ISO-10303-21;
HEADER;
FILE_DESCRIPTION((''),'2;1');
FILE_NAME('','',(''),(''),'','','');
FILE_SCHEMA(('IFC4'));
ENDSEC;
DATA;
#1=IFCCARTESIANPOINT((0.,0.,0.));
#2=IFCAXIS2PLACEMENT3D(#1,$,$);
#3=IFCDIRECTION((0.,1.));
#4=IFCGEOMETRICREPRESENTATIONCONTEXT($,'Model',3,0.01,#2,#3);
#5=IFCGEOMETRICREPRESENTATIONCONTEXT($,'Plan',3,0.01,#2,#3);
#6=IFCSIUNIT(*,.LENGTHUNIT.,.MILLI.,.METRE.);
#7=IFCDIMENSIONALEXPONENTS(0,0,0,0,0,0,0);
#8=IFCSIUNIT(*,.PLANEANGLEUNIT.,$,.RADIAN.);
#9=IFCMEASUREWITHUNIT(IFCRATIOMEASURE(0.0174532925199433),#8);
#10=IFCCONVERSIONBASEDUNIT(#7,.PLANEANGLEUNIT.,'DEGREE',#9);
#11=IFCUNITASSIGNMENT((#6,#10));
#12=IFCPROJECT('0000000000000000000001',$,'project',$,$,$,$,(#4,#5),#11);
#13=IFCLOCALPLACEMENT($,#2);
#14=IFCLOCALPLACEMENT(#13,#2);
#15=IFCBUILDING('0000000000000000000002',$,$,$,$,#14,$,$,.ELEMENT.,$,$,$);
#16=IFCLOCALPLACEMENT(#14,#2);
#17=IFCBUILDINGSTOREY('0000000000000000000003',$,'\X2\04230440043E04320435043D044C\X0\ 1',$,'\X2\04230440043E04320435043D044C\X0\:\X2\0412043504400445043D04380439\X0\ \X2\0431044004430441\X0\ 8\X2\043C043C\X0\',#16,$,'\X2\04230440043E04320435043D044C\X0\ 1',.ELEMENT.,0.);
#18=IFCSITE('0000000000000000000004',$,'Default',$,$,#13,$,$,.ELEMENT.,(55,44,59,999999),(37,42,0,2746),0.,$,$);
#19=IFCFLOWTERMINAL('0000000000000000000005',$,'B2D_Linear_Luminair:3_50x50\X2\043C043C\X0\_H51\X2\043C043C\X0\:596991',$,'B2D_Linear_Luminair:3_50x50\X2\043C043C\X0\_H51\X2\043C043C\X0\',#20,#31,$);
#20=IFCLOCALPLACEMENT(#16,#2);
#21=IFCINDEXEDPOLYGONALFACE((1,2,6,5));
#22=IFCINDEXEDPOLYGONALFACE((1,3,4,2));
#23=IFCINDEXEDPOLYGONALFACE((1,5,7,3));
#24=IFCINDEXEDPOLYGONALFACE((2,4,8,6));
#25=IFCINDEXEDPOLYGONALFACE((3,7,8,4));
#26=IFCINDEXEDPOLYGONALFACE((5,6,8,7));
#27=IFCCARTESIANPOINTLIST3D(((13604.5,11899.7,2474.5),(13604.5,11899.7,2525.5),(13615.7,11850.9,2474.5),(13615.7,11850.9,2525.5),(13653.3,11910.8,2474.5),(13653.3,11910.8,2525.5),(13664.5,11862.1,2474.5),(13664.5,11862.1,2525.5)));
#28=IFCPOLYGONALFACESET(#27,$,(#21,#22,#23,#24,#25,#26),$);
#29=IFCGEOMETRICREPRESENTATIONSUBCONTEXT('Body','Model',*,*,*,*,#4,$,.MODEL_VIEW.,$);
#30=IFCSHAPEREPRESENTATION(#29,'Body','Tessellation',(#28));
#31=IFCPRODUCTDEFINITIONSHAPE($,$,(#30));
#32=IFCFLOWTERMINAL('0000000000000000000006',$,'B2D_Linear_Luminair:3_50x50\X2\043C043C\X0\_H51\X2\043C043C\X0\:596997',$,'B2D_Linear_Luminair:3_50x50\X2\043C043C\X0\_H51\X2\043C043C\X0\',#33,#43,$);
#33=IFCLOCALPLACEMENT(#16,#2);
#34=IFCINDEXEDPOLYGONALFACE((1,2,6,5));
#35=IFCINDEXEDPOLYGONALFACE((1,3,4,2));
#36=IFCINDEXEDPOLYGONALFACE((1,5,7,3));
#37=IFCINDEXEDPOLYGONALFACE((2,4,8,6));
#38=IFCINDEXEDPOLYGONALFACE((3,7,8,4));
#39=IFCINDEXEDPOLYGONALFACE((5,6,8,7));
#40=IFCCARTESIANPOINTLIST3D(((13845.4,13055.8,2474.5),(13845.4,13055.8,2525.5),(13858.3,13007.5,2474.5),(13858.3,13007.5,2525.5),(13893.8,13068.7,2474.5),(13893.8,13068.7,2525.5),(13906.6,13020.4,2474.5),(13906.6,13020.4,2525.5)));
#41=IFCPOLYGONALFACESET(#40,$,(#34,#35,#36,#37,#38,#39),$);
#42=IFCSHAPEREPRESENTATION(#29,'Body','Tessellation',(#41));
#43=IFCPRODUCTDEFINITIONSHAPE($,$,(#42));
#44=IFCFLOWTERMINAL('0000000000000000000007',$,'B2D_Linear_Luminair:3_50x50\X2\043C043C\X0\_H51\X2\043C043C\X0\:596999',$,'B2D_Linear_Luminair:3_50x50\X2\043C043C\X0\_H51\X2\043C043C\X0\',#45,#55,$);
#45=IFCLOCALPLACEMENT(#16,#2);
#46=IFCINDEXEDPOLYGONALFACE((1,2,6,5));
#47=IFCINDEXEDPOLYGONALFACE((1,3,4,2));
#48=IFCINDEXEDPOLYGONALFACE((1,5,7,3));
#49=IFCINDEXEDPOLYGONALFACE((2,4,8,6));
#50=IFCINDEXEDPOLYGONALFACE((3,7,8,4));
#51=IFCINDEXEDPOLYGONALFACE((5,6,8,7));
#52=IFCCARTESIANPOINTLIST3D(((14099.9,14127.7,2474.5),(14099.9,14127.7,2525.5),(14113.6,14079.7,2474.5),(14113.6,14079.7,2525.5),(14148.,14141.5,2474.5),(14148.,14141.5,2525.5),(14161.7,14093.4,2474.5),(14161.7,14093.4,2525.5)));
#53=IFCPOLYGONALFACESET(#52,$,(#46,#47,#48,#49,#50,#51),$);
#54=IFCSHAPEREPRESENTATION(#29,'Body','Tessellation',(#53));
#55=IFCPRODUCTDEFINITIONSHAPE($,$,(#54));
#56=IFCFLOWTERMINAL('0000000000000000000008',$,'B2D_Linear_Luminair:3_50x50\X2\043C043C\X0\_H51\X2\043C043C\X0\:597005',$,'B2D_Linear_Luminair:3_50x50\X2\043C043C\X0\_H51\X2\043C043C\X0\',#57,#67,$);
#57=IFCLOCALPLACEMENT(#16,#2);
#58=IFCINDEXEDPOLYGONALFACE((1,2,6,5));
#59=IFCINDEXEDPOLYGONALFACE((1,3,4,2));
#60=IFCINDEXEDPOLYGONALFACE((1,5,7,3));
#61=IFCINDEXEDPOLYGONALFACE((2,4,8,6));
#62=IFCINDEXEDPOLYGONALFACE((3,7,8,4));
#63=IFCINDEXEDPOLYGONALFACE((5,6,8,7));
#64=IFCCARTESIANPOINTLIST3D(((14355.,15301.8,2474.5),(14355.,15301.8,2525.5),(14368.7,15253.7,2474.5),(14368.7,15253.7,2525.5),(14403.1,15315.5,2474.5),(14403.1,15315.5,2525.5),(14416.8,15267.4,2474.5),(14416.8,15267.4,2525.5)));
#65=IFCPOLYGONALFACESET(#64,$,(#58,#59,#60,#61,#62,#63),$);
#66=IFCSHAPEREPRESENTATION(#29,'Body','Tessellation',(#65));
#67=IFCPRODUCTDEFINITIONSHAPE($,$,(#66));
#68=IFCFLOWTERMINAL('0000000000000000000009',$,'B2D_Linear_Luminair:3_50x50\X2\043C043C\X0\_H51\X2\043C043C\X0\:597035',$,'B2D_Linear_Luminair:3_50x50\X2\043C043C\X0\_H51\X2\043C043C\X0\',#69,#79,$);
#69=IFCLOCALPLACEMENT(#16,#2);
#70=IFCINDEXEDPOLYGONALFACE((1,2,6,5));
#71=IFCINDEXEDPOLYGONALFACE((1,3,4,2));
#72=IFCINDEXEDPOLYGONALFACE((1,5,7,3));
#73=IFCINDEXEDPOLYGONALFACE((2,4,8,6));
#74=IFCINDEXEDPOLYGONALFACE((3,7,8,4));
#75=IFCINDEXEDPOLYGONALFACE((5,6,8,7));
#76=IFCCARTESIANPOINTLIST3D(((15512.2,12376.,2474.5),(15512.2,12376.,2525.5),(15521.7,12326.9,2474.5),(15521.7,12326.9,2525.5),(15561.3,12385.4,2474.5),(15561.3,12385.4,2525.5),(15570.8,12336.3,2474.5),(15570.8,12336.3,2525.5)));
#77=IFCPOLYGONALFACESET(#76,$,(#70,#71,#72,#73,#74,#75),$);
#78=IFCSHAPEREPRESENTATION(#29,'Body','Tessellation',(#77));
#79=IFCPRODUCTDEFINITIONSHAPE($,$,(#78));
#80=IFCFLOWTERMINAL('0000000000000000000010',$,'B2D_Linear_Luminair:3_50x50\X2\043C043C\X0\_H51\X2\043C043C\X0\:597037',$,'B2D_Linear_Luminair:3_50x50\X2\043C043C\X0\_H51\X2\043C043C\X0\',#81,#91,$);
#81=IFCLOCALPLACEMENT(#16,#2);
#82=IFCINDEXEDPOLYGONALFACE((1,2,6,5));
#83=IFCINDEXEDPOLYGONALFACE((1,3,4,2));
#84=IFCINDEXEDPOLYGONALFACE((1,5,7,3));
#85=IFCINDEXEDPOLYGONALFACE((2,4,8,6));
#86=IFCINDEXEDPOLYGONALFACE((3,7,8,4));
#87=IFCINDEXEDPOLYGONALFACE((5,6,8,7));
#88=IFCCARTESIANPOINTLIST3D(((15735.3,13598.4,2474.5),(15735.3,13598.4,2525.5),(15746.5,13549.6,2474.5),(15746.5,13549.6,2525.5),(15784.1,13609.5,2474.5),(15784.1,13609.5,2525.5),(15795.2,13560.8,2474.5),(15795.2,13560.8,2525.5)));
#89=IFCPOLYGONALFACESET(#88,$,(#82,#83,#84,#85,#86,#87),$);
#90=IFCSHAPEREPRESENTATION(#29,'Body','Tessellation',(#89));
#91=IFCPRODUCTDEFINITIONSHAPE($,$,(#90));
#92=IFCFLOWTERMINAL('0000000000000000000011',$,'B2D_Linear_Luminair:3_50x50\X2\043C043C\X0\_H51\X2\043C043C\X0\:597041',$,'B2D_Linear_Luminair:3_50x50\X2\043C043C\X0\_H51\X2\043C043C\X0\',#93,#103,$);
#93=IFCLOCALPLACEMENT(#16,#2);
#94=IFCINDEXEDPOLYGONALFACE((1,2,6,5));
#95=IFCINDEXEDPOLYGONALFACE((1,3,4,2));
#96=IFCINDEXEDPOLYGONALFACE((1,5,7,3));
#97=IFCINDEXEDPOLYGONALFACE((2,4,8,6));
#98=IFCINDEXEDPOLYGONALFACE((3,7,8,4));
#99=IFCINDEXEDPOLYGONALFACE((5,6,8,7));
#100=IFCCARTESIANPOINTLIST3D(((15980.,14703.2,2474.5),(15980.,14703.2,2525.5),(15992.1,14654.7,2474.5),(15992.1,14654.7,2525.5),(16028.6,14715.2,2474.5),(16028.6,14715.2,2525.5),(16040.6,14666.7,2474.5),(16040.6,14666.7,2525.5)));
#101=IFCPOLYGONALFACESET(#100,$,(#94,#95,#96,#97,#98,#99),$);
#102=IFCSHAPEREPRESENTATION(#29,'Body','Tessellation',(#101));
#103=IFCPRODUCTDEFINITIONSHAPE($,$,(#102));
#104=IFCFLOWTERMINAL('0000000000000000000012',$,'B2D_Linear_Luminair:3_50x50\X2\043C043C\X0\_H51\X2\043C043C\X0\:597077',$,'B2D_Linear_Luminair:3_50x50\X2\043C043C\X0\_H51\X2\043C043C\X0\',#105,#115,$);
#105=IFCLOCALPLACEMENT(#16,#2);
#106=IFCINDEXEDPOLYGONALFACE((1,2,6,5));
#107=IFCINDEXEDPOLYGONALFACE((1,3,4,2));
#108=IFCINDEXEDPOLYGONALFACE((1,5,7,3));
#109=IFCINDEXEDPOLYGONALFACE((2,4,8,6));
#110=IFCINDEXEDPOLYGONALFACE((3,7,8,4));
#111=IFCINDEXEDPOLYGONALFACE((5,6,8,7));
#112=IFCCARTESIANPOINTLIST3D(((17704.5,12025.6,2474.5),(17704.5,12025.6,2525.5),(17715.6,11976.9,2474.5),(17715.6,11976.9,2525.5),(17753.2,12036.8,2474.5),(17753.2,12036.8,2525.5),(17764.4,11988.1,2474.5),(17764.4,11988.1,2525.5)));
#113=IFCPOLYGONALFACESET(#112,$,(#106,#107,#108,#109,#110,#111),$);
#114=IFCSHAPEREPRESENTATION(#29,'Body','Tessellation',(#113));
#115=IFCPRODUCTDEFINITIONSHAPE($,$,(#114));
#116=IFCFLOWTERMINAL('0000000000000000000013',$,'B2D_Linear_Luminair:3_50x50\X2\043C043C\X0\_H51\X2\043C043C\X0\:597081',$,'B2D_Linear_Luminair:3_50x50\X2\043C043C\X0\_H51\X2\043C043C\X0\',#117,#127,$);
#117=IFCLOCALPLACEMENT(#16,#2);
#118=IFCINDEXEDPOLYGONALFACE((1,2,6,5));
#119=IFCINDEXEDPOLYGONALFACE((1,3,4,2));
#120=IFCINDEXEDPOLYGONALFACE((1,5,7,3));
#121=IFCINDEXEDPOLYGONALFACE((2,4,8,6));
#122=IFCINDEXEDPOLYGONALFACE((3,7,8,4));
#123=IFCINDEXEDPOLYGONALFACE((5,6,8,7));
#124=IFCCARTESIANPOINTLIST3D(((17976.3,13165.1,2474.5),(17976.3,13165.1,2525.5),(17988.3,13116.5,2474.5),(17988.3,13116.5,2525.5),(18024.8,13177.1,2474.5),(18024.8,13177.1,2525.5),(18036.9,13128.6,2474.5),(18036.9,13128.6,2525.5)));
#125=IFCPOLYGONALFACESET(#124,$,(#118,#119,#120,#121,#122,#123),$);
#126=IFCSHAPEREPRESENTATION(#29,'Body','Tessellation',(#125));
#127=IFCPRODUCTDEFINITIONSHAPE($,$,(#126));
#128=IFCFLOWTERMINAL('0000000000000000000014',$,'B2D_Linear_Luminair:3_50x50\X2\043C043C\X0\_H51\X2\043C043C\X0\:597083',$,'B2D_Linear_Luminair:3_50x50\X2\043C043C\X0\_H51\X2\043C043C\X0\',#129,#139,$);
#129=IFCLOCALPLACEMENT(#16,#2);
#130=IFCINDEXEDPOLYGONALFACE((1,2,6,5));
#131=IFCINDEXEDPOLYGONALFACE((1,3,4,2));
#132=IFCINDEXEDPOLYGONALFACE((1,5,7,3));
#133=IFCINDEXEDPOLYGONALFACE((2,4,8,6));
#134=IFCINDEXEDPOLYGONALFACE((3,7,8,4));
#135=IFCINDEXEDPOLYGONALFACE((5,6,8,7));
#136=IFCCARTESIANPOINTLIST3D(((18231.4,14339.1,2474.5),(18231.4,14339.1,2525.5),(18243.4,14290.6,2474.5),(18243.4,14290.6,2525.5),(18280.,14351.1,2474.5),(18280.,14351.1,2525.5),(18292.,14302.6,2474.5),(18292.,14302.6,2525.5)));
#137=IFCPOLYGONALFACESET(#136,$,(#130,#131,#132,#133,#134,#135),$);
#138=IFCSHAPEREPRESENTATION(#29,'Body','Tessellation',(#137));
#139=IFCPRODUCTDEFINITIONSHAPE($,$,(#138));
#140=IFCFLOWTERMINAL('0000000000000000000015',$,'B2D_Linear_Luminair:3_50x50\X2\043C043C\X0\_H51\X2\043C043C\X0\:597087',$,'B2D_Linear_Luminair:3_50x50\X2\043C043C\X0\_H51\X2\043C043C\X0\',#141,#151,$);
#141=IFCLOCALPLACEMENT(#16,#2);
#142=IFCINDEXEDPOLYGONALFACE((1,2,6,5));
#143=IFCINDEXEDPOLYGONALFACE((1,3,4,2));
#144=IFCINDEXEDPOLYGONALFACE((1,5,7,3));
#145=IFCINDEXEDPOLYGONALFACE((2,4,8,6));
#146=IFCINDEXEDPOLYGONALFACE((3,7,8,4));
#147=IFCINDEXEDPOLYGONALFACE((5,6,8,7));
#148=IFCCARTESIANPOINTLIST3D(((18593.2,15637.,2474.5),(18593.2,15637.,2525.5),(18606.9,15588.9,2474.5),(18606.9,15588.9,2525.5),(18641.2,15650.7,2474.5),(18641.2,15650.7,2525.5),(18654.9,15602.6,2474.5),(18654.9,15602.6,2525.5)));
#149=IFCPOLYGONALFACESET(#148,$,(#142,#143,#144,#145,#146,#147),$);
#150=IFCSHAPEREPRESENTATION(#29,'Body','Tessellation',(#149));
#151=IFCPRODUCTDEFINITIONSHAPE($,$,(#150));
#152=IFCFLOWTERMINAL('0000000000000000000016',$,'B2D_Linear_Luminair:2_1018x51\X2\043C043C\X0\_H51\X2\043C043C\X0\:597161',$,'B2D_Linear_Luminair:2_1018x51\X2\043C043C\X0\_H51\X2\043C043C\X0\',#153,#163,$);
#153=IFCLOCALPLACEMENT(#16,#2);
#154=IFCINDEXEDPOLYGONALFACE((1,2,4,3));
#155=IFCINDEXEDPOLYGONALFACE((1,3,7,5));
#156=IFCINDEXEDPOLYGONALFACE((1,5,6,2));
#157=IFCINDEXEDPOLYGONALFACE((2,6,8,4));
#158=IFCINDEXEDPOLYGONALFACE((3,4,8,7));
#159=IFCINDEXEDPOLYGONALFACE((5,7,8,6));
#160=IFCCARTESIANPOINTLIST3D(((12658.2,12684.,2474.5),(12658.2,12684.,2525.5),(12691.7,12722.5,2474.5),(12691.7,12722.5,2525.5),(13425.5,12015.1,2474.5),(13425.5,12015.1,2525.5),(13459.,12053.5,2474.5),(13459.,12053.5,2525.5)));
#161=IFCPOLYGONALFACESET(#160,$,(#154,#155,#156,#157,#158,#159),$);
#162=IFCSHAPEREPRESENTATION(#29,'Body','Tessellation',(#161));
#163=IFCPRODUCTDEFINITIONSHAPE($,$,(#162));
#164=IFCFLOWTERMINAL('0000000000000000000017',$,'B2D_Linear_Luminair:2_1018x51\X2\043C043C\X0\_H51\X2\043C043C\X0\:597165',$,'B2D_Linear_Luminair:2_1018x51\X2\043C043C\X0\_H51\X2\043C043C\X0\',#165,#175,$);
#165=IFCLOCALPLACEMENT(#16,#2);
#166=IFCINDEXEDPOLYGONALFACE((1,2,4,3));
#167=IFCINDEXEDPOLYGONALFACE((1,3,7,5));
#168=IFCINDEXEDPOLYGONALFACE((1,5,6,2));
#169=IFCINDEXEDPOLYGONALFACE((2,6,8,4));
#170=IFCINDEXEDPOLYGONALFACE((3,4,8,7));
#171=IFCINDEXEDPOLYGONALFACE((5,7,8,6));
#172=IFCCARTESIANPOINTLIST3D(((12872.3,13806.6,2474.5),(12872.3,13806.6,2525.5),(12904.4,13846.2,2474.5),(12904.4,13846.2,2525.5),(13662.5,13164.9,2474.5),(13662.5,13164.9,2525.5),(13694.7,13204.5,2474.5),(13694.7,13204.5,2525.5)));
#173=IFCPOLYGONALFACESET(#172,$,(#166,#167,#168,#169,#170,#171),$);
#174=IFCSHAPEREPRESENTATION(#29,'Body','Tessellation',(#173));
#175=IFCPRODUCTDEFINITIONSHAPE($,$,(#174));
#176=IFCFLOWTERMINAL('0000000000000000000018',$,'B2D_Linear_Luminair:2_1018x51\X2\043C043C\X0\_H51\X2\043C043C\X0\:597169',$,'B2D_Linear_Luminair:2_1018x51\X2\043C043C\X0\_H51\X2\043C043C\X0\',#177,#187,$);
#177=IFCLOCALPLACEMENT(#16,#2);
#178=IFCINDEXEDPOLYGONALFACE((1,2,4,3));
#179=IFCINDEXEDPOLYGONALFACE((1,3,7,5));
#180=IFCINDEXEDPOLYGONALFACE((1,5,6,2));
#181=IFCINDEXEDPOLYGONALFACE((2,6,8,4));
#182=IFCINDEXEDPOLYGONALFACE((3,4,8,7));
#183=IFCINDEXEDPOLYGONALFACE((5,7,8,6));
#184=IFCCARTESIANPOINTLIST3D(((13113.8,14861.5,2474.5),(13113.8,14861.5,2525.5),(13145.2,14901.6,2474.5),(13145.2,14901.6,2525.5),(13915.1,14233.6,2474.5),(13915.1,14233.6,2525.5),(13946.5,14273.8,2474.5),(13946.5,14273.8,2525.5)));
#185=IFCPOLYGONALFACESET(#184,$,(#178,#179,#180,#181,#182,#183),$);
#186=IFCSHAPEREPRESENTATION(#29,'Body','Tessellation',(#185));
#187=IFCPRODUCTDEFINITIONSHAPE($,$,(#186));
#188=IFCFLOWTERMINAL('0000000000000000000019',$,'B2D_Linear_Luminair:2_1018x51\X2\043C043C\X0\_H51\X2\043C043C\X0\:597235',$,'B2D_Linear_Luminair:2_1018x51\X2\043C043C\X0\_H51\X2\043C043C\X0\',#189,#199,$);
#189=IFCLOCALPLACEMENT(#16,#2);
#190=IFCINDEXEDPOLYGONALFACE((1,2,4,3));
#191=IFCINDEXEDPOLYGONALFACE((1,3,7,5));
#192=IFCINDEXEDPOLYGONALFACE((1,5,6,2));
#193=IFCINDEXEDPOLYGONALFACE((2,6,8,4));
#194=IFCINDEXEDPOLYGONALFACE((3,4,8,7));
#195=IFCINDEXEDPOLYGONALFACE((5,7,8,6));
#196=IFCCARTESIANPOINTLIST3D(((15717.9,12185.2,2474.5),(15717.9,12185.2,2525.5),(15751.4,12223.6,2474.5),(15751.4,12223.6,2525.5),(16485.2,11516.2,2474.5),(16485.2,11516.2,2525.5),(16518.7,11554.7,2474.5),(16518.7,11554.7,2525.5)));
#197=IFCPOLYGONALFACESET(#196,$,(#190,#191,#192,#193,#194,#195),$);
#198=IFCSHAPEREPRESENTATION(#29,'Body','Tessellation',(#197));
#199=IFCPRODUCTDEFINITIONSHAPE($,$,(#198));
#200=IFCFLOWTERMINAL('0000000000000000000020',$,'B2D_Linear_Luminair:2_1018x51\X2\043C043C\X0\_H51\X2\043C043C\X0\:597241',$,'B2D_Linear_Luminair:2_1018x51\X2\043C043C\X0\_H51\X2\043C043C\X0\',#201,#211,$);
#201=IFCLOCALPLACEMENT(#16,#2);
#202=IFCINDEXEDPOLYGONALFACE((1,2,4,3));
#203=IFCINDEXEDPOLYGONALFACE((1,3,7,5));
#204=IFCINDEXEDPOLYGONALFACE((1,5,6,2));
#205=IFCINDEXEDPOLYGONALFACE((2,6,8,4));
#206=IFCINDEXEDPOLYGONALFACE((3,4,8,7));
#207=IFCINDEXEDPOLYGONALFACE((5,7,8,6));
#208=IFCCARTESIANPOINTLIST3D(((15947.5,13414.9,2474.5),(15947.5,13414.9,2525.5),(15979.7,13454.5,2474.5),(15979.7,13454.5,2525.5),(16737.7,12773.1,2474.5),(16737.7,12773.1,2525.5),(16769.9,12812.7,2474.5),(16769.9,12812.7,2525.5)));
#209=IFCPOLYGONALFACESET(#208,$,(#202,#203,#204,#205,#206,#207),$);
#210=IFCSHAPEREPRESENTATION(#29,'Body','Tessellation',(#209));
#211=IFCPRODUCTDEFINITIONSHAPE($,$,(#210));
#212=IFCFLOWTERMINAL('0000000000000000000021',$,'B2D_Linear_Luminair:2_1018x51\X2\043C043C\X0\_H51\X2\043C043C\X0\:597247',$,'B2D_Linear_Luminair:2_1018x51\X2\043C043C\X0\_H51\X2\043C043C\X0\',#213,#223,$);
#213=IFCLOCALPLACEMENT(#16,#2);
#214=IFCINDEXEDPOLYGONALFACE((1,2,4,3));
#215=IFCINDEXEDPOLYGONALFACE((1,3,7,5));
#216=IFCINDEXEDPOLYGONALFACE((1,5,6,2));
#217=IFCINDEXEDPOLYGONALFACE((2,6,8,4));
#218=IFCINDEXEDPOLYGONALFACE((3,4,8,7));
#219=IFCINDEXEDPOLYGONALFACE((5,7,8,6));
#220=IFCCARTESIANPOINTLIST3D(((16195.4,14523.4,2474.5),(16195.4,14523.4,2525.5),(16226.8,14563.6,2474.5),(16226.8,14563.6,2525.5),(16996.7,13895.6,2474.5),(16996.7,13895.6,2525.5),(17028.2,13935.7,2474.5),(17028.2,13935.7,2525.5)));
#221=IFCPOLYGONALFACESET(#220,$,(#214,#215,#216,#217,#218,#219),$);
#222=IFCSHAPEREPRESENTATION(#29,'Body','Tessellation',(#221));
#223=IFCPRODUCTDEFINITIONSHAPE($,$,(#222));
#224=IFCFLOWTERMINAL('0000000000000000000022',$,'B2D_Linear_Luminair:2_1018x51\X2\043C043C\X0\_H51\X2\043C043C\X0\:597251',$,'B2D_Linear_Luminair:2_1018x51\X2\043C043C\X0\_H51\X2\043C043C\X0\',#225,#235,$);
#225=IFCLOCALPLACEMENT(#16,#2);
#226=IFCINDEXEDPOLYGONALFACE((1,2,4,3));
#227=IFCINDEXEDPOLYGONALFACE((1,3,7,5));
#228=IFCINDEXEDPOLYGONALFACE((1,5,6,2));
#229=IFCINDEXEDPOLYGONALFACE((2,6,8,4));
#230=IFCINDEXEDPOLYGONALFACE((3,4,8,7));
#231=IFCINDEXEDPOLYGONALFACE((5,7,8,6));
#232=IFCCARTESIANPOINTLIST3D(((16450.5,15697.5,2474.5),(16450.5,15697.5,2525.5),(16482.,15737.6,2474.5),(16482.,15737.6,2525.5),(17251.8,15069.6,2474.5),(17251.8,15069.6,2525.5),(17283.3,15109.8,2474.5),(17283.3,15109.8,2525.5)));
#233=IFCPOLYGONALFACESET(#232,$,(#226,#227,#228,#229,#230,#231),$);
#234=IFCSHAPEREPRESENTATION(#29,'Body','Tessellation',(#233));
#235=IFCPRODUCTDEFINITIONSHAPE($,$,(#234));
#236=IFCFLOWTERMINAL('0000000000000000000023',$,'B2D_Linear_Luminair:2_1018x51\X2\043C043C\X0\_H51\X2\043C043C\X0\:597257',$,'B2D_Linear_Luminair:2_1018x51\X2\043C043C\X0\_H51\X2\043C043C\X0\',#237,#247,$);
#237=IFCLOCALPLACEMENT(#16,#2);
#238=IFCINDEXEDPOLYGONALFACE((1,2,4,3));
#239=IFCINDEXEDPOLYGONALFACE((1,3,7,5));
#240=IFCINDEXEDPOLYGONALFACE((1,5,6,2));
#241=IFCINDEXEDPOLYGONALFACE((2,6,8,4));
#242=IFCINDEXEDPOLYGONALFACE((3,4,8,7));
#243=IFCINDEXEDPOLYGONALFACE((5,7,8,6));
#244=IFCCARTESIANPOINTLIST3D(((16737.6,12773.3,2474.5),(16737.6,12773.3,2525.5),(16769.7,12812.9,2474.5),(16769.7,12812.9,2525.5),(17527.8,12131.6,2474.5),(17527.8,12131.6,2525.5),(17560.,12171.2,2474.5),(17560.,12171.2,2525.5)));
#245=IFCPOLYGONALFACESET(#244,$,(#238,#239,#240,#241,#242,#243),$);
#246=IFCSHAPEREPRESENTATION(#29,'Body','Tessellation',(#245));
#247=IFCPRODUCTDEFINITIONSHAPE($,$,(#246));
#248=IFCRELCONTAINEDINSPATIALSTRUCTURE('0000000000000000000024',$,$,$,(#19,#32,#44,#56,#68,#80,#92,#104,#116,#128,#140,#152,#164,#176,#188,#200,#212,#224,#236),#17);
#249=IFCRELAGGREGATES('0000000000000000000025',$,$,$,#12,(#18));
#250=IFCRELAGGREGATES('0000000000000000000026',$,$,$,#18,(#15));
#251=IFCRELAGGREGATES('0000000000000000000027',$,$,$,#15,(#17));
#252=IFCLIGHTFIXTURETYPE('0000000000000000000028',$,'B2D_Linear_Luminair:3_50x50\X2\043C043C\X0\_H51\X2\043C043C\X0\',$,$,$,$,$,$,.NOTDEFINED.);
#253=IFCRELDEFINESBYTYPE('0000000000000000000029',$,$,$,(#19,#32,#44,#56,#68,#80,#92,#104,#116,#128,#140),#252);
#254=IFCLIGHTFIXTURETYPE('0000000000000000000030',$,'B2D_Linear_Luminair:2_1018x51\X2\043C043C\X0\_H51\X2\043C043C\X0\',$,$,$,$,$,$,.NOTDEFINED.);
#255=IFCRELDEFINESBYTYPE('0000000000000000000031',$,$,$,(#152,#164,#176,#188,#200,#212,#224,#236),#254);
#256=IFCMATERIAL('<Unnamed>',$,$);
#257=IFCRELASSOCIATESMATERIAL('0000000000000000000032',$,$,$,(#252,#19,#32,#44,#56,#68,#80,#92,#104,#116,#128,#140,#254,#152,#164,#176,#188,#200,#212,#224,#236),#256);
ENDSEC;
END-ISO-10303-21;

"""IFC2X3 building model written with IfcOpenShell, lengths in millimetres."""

from ifc_helpers import new_model, entity, si_unit, converted_unit, direction, frame, origin, origin_2d_with_axis, place, context, subcontext, project, spatial, rectangle, extrude, source, transform, mapped, material, type_object, type_shapes, element, save


model = new_model("IFC2X3")

# Units and contexts
model_context = context("Model", 3, precision=0.01, world=origin(), true_north=direction((0.0, 1.0)))
plan_context = context("Plan", 3, precision=0.01, world=origin(), true_north=direction((0.0, 1.0)))
body_context = subcontext(model_context, "Body", "Model", "MODEL_VIEW")
ifc_project = project(units=[si_unit("LENGTHUNIT", "METRE", prefix="MILLI"), converted_unit("PLANEANGLEUNIT", "DEGREE", entity("IfcRatioMeasure", 0.0174532925199433), si_unit("PLANEANGLEUNIT", "RADIAN"), dimensions=[0, 0, 0, 0, 0, 0, 0])], contexts=[model_context, plan_context])

# Site, building, storey
site_placement = place(None, origin())
site = spatial("IfcSite", under=ifc_project, at=site_placement, Name="Default", CompositionType="ELEMENT", RefLatitude=(55, 44, 59, 999999), RefLongitude=(37, 42, 0, 2746), RefElevation=0.0)
building_placement = place(site_placement, origin())
building = spatial("IfcBuilding", under=site, at=building_placement, CompositionType="ELEMENT")
storey_placement = place(building_placement, origin())
storey = spatial("IfcBuildingStorey", under=building, at=storey_placement, Name="Уровень 1", ObjectType="Уровень:Верхний брус 8мм", LongName="Уровень 1", CompositionType="ELEMENT", Elevation=0.0)

# Flow terminals
ifc_material = material(Name="<Unnamed>")
light_fixture_type_1 = type_object("IfcLightFixtureType", Name="B2D_Linear_Luminair:3_50x50мм_H51мм", PredefinedType="NOTDEFINED", material=ifc_material)
shared_shape_1 = source(origin(), body_context, "Body", "SweptSolid", [
    extrude(rectangle(XDim=50.0, YDim=50.0, at=origin_2d_with_axis()), frame((0.0, 0.0, 0.0), z_axis=(0.0, 0.0, 1.0), x_axis=(-1.0, 0.0, 0.0)), (0.0, 0.0, 1.0), 51.0),
])
type_shapes(light_fixture_type_1, [shared_shape_1])
for number, where, z_axis, x_axis, name in (
    (1, (13634.5, 11880.9, 2525.5), (0.0, 0.0, -1.0), (0.974683, 0.22359, 0.0), "B2D_Linear_Luminair:3_50x50мм_H51мм:596991"),
    (2, (13876.0, 13038.1, 2525.5), (0.0, 0.0, -1.0), (0.966286, 0.25747, 0.0), "B2D_Linear_Luminair:3_50x50мм_H51мм:596997"),
    (3, (14130.8, 14110.6, 2525.5), (0.0, 0.0, -1.0), (0.961646, 0.274295, 0.0), "B2D_Linear_Luminair:3_50x50мм_H51мм:596999"),
    (4, (14385.9, 15284.6, 2525.5), (0.0, 0.0, -1.0), (0.961646, 0.274295, 0.0), "B2D_Linear_Luminair:3_50x50мм_H51мм:597005"),
    (5, (15541.5, 12356.1, 2525.5), (0.0, 0.0, -1.0), (0.981893, 0.189438, 0.0), "B2D_Linear_Luminair:3_50x50мм_H51мм:597035"),
    (6, (15765.3, 13579.6, 2525.5), (0.0, 0.0, -1.0), (0.974683, 0.22359, 0.0), "B2D_Linear_Luminair:3_50x50мм_H51мм:597037"),
    (7, (16010.3, 14685.0, 2525.5), (0.0, 0.0, -1.0), (0.970633, 0.240567, 0.0), "B2D_Linear_Luminair:3_50x50мм_H51мм:597041"),
    (8, (17734.4, 12006.9, 2525.5), (0.0, 0.0, -1.0), (0.974683, 0.22359, 0.0), "B2D_Linear_Luminair:3_50x50мм_H51мм:597077"),
    (9, (18006.6, 13146.8, 2525.5), (0.0, 0.0, -1.0), (0.970633, 0.240567, 0.0), "B2D_Linear_Luminair:3_50x50мм_H51мм:597081"),
    (10, (18261.7, 14320.9, 2525.5), (0.0, 0.0, -1.0), (0.970633, 0.240567, 0.0), "B2D_Linear_Luminair:3_50x50мм_H51мм:597083"),
    (11, (18624.0, 15619.8, 2525.5), (0.0, 0.0, -1.0), (0.961646, 0.274295, 0.0), "B2D_Linear_Luminair:3_50x50мм_H51мм:597087"),
):
    element("IfcFlowTerminal", number, at=place(storey_placement, frame(where, z_axis=z_axis, x_axis=x_axis)), inside=storey, type_object=light_fixture_type_1, material=ifc_material, Name=name, ObjectType="B2D_Linear_Luminair:3_50x50мм_H51мм", context=body_context, shape_type="MappedRepresentation", body=[
        mapped(shared_shape_1, transform((0.0, 0.0, 0.0), scale=1.0)),
    ])
light_fixture_type_2 = type_object("IfcLightFixtureType", Name="B2D_Linear_Luminair:2_1018x51мм_H51мм", PredefinedType="NOTDEFINED", material=ifc_material)
shared_shape_2 = source(origin(), body_context, "Body", "SweptSolid", [
    extrude(rectangle(XDim=1018.0, YDim=51.0, at=origin_2d_with_axis()), frame((0.0, 0.0, 0.0), z_axis=(0.0, 0.0, 1.0), x_axis=(-1.0, 0.0, 0.0)), (0.0, 0.0, 1.0), 51.0),
])
type_shapes(light_fixture_type_2, [shared_shape_2])
for number, where, z_axis, x_axis, name in (
    (12, (13058.6, 12368.8, 2525.5), (0.0, 0.0, -1.0), (0.753793, -0.657112, 0.0), "B2D_Linear_Luminair:2_1018x51мм_H51мм:597161"),
    (13, (13283.5, 13505.6, 2525.5), (0.0, 0.0, -1.0), (0.776267, -0.630405, 0.0), "B2D_Linear_Luminair:2_1018x51мм_H51мм:597165"),
    (14, (13530.2, 14567.6, 2525.5), (0.0, 0.0, -1.0), (0.78715, -0.616761, 0.0), "B2D_Linear_Luminair:2_1018x51мм_H51мм:597169"),
    (15, (16118.3, 11869.9, 2525.5), (0.0, 0.0, -1.0), (0.753793, -0.657112, 0.0), "B2D_Linear_Luminair:2_1018x51мм_H51мм:597235"),
    (16, (16358.7, 13113.8, 2525.5), (0.0, 0.0, -1.0), (0.776267, -0.630405, 0.0), "B2D_Linear_Luminair:2_1018x51мм_H51мм:597241"),
    (17, (16611.8, 14229.6, 2525.5), (0.0, 0.0, -1.0), (0.78715, -0.616761, 0.0), "B2D_Linear_Luminair:2_1018x51мм_H51мм:597247"),
    (18, (16866.9, 15403.6, 2525.5), (0.0, 0.0, -1.0), (0.78715, -0.616761, 0.0), "B2D_Linear_Luminair:2_1018x51мм_H51мм:597251"),
    (19, (17148.8, 12472.2, 2525.5), (0.0, 0.0, -1.0), (0.776267, -0.630405, 0.0), "B2D_Linear_Luminair:2_1018x51мм_H51мм:597257"),
):
    element("IfcFlowTerminal", number, at=place(storey_placement, frame(where, z_axis=z_axis, x_axis=x_axis)), inside=storey, type_object=light_fixture_type_2, material=ifc_material, Name=name, ObjectType="B2D_Linear_Luminair:2_1018x51мм_H51мм", context=body_context, shape_type="MappedRepresentation", body=[
        mapped(shared_shape_2, transform((0.0, 0.0, 0.0), scale=1.0)),
    ])

save(model, "model.ifc")
